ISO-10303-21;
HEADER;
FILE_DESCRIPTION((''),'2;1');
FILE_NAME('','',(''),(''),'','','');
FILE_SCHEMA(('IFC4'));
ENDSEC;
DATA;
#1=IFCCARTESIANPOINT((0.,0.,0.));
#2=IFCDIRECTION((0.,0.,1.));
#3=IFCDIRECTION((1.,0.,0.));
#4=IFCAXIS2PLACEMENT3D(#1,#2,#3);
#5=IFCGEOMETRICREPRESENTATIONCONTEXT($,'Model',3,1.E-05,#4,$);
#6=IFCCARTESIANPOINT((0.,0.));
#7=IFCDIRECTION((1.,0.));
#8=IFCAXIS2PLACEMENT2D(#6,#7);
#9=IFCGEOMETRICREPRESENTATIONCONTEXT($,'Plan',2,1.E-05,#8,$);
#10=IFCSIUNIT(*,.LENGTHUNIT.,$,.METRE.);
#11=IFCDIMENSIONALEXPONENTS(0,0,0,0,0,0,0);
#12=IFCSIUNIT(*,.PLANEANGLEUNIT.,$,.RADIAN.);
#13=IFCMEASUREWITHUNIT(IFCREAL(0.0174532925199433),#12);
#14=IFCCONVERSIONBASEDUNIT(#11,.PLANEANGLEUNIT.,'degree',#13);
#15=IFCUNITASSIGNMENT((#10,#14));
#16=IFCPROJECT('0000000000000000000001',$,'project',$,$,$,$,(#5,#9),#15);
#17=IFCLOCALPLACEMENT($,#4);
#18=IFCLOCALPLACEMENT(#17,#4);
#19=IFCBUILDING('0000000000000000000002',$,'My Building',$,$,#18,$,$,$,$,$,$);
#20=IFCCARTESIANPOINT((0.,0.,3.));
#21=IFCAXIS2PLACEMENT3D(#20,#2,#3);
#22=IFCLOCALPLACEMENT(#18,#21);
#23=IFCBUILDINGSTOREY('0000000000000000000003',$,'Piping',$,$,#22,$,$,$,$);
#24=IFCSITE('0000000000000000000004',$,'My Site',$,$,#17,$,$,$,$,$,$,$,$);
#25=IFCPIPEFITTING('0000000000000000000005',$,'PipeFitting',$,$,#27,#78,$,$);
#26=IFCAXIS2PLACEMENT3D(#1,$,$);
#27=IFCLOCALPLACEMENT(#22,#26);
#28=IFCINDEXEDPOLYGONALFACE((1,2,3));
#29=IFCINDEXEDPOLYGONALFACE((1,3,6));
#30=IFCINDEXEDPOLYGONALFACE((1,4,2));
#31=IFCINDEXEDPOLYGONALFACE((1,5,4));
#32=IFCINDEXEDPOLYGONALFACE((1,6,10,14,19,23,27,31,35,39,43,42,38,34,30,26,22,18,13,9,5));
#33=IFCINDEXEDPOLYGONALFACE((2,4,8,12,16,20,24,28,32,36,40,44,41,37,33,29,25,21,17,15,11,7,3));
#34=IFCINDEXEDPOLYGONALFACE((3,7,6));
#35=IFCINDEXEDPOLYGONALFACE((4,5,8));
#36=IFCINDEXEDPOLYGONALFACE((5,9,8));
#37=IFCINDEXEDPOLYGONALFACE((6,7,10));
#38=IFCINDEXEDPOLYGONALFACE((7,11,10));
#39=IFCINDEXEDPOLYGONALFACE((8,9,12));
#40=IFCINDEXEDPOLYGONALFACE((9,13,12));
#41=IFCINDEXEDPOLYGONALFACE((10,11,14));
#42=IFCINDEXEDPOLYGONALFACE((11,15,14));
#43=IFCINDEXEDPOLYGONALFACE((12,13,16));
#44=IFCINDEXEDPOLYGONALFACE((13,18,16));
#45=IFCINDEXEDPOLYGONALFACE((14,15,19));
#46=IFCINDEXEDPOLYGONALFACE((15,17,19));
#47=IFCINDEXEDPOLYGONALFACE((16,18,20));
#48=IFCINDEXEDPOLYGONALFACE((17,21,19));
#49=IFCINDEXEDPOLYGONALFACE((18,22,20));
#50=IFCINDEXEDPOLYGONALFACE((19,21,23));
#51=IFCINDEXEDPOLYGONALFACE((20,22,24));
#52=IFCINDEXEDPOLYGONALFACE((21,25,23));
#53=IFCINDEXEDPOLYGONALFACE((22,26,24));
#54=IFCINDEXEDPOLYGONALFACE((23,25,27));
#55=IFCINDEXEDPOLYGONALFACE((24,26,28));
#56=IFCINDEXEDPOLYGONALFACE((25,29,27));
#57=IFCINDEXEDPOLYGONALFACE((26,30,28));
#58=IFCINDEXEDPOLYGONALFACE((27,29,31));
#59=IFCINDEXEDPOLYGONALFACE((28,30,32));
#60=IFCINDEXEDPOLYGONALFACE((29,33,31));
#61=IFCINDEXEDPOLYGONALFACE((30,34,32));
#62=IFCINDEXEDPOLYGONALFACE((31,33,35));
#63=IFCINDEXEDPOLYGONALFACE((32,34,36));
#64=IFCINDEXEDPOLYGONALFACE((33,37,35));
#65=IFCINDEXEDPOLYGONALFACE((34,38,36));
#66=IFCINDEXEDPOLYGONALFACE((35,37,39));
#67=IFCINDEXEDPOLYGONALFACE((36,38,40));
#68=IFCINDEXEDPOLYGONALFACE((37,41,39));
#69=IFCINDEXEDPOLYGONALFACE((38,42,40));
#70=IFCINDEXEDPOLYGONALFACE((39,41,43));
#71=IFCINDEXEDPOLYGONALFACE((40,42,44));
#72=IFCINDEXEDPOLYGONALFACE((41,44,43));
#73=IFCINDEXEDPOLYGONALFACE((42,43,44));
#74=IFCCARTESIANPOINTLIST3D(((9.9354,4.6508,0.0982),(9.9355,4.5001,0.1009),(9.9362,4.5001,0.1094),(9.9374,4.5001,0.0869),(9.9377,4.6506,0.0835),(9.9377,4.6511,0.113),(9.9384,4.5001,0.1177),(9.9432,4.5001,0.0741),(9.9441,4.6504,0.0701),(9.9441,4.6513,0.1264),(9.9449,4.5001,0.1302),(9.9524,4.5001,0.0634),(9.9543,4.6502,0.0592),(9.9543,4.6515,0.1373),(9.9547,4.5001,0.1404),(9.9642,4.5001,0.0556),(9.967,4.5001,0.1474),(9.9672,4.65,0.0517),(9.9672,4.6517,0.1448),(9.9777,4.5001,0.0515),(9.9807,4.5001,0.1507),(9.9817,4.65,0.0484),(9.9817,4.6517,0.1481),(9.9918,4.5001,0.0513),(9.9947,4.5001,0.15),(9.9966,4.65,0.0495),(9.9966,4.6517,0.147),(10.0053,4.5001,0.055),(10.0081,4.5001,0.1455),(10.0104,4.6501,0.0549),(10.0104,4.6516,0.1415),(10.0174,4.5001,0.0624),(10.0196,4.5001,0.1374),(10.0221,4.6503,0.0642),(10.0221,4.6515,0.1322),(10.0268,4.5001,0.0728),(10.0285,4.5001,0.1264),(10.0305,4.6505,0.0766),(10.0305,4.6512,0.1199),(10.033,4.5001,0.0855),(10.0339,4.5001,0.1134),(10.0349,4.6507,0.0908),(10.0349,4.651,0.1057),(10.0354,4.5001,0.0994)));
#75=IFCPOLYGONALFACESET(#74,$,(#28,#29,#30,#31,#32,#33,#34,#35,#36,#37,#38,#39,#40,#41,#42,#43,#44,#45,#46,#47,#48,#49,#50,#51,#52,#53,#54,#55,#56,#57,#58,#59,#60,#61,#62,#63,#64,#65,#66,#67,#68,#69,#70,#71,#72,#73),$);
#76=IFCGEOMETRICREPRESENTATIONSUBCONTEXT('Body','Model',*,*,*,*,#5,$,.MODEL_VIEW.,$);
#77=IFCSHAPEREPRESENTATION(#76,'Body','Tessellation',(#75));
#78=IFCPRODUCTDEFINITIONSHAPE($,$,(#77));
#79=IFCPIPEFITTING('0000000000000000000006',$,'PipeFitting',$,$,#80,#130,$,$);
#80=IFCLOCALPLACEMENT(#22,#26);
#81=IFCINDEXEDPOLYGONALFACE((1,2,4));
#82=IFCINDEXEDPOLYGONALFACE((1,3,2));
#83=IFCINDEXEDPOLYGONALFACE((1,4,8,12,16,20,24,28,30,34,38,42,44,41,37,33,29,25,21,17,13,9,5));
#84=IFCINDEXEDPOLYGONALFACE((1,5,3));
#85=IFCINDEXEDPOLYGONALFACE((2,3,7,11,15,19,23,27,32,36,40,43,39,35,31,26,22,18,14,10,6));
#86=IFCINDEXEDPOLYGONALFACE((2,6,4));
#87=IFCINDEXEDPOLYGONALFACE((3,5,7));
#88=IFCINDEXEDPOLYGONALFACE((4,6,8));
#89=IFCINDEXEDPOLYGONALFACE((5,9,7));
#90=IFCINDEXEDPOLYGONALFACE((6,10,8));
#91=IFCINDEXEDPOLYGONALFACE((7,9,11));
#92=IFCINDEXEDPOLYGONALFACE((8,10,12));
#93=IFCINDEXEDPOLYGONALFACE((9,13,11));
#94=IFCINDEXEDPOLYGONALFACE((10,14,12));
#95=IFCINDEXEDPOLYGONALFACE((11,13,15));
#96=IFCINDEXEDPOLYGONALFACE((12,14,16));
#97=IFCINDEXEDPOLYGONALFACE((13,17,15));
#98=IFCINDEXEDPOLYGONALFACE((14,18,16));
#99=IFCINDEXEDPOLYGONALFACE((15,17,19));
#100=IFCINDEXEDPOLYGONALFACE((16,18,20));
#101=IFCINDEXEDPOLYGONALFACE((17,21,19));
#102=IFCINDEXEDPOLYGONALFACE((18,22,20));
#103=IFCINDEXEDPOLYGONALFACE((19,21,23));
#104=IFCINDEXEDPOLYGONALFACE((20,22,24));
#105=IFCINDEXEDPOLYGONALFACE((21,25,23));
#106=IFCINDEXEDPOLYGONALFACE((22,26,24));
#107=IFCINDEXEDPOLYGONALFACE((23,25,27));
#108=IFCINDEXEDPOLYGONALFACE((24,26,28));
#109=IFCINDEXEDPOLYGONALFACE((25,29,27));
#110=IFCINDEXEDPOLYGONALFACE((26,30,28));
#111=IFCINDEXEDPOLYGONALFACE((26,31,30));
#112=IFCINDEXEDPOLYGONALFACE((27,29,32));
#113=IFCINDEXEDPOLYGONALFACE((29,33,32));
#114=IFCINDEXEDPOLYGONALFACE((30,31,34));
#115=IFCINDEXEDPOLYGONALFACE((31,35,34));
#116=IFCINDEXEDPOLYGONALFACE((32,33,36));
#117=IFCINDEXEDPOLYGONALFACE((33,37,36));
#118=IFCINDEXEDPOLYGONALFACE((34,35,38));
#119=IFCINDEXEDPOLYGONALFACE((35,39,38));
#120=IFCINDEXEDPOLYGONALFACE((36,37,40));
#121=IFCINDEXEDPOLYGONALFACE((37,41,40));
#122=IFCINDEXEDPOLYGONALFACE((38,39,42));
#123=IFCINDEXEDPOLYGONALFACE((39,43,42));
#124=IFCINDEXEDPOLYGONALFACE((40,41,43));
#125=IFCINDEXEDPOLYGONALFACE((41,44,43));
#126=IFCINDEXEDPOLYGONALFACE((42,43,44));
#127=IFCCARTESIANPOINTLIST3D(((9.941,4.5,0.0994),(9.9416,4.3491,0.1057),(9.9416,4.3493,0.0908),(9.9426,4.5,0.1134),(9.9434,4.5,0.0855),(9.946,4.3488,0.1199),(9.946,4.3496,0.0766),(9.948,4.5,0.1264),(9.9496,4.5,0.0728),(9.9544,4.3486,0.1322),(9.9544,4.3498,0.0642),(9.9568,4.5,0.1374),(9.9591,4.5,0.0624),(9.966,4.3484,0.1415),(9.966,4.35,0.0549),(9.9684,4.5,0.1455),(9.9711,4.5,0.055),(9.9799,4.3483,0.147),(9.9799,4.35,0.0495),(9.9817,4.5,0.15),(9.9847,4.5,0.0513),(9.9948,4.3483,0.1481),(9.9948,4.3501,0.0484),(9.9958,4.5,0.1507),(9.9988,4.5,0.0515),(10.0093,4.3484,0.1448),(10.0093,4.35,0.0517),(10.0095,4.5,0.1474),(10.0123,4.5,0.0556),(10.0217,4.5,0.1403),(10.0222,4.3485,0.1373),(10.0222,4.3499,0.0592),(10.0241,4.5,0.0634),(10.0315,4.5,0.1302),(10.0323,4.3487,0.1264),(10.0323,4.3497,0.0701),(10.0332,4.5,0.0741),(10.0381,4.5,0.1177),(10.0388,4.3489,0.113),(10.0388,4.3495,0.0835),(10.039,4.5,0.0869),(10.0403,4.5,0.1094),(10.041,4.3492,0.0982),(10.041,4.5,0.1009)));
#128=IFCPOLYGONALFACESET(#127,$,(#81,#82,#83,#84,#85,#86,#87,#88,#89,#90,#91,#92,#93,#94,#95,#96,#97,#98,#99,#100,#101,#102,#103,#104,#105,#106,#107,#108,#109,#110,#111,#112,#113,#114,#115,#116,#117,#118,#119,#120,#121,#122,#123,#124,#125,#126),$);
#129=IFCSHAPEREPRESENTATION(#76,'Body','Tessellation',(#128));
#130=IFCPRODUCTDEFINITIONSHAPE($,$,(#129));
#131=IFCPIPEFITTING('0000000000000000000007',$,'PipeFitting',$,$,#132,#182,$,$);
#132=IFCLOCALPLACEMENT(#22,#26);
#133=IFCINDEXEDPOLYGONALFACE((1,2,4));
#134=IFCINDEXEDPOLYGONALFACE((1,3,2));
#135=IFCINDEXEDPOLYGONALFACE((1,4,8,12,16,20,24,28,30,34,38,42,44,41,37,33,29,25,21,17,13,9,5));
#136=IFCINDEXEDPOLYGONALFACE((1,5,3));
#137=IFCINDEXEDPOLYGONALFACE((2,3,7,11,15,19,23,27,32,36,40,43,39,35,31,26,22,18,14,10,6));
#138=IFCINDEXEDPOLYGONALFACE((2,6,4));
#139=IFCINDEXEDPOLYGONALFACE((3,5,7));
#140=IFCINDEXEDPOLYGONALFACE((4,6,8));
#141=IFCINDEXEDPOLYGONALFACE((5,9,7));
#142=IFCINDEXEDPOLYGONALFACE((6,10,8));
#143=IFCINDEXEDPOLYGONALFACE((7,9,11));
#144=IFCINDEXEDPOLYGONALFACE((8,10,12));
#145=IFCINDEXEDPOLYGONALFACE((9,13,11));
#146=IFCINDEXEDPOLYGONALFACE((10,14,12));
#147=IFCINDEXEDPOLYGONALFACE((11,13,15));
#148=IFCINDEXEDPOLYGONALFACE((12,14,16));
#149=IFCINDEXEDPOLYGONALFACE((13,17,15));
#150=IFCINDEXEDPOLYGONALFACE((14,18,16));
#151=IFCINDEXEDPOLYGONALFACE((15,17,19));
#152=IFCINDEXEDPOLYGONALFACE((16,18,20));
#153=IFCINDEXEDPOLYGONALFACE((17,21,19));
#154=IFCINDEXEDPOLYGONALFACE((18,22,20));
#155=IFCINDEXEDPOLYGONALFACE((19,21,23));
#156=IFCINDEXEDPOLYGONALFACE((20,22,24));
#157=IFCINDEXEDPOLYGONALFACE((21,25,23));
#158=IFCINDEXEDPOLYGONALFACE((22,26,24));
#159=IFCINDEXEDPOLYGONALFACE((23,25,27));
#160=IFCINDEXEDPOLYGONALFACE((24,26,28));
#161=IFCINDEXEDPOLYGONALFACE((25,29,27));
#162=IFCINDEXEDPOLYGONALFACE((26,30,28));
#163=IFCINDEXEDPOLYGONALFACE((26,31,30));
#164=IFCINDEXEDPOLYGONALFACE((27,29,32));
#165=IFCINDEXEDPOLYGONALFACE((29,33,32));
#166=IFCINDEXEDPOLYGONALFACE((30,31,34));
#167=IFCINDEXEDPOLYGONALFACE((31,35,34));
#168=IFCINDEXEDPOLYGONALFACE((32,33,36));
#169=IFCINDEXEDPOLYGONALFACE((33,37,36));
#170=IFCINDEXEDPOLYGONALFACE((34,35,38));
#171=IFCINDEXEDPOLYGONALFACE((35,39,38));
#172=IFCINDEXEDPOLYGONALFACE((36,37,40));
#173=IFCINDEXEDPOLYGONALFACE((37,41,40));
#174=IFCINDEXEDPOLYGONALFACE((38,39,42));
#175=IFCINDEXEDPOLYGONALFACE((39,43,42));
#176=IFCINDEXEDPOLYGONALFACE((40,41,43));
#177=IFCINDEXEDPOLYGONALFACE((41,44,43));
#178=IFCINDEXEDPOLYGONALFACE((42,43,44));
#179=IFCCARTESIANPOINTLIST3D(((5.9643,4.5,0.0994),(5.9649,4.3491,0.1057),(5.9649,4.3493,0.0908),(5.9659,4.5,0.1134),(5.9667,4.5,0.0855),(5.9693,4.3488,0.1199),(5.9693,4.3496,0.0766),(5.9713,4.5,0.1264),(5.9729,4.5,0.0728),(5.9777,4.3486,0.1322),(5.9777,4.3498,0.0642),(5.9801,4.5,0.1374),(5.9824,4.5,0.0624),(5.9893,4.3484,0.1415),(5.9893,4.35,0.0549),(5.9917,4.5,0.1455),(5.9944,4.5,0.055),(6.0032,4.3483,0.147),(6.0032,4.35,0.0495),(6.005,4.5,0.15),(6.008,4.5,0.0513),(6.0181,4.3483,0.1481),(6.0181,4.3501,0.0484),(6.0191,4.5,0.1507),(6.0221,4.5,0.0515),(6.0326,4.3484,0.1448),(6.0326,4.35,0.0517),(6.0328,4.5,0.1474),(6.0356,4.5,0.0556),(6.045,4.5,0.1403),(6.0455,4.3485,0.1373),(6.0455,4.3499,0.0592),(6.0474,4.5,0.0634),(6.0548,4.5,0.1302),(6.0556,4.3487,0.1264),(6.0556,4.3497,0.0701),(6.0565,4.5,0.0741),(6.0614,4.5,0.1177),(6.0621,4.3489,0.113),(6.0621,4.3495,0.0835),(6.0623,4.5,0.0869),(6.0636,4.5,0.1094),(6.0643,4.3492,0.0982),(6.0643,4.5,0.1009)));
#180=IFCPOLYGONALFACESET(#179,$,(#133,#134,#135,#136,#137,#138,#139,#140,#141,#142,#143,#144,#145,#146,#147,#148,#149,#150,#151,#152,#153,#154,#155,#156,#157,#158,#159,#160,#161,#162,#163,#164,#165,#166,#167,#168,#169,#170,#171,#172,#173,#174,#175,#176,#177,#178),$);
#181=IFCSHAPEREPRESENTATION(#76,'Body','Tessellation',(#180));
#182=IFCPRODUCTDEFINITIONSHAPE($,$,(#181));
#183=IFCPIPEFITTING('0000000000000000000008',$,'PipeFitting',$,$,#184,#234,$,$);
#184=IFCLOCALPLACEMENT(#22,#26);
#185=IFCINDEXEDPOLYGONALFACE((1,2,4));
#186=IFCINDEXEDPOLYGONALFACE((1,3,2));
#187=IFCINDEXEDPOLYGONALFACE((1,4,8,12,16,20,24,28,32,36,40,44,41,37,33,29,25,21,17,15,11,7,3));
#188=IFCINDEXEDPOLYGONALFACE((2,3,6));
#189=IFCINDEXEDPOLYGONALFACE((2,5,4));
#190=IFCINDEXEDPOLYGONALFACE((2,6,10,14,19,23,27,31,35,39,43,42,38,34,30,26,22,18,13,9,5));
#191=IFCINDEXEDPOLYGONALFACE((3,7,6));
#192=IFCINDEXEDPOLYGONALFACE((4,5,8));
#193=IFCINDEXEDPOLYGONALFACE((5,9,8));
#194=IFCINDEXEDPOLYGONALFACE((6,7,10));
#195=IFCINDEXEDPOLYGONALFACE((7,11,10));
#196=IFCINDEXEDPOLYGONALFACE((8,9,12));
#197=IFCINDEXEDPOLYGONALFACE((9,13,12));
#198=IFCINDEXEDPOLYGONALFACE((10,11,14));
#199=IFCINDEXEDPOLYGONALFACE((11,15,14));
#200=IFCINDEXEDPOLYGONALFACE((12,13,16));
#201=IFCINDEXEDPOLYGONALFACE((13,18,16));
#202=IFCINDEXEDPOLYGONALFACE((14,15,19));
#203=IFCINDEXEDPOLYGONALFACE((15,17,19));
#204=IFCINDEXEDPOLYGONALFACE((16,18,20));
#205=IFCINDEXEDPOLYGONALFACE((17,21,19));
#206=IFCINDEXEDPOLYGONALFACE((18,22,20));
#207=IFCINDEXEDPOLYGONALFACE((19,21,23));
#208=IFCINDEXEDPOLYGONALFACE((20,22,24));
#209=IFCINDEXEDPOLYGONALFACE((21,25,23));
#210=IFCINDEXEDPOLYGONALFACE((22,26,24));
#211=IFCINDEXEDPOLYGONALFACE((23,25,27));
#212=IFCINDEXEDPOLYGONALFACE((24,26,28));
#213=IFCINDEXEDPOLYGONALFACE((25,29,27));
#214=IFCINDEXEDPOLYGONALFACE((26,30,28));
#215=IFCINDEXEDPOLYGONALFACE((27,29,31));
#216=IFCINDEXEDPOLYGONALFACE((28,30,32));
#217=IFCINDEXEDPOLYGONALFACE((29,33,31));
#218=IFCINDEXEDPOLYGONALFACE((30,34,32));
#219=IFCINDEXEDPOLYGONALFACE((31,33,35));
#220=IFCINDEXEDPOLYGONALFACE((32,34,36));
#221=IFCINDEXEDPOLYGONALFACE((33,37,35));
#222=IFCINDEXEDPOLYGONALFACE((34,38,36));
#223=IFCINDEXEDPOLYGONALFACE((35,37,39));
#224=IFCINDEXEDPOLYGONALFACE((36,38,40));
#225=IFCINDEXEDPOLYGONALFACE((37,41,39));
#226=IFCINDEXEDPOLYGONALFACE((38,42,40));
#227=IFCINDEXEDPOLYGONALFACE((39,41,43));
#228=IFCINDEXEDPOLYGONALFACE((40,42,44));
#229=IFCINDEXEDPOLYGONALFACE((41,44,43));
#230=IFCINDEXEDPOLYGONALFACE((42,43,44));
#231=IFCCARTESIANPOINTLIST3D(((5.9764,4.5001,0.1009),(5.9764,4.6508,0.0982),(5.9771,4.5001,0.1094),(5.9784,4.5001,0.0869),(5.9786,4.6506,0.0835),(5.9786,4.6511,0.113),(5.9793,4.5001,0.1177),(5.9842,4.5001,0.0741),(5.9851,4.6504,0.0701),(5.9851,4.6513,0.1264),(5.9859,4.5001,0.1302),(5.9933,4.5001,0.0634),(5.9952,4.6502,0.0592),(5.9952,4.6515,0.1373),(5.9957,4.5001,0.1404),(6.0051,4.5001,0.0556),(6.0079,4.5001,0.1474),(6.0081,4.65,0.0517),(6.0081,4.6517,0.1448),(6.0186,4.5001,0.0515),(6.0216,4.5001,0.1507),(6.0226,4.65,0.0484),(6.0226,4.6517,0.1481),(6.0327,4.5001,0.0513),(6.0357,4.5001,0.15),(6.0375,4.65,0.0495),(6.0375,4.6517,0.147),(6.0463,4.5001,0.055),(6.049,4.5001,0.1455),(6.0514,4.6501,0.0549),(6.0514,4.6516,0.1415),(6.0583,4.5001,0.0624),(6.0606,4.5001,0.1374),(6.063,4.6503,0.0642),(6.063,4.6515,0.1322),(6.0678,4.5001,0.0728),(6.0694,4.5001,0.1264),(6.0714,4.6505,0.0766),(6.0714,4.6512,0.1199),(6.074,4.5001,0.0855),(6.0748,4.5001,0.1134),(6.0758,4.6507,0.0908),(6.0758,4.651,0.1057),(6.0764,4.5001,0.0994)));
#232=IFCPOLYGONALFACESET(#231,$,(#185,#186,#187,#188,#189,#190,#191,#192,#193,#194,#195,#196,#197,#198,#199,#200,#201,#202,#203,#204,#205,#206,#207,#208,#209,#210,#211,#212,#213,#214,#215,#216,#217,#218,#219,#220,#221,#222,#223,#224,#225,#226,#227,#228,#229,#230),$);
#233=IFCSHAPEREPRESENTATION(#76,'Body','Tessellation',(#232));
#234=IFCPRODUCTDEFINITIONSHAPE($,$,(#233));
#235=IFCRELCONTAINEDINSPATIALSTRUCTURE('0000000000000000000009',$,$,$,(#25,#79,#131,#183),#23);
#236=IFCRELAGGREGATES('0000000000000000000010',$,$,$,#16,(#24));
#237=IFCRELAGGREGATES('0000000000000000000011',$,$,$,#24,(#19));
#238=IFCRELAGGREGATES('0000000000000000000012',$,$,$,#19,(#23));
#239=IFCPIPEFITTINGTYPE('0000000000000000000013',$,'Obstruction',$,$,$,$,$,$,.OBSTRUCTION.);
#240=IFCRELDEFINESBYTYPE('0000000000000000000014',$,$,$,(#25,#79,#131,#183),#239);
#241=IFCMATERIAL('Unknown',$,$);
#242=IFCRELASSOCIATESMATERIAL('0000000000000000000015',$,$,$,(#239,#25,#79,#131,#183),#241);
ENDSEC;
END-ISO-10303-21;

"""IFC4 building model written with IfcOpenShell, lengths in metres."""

from ifc_helpers import new_model, entity, si_unit, converted_unit, frame, origin_with_axes, origin_2d_with_axis, place, context, subcontext, project, spatial, circle, extrude, clip, halfspace, material, material_profile, profile_set, profile_usage, type_object, element, save


model = new_model("IFC4")

# Units and contexts
model_context = context("Model", 3, precision=1e-05, world=origin_with_axes())
plan_context = context("Plan", 2, precision=1e-05, world=origin_2d_with_axis())
body_context = subcontext(model_context, "Body", "Model", "MODEL_VIEW")
ifc_project = project(units=[si_unit("LENGTHUNIT", "METRE"), converted_unit("PLANEANGLEUNIT", "degree", entity("IfcReal", 0.0174532925199433), si_unit("PLANEANGLEUNIT", "RADIAN"), dimensions=[0, 0, 0, 0, 0, 0, 0])], contexts=[model_context, plan_context])

# Site, building, storey
site_placement = place(None, origin_with_axes())
site = spatial("IfcSite", under=ifc_project, at=site_placement, Name="My Site")
building_placement = place(site_placement, origin_with_axes())
building = spatial("IfcBuilding", under=site, at=building_placement, Name="My Building")
storey_placement = place(building_placement, frame((0.0, 0.0, 3.0), z_axis=(0.0, 0.0, 1.0), x_axis=(1.0, 0.0, 0.0)))
storey = spatial("IfcBuildingStorey", under=building, at=storey_placement, Name="Piping")

# Shared definitions
ifc_material = material(Name="Unknown")

# Pipe fittings
ifc_material_profile_1 = material_profile(ifc_material, circle(Radius=0.05))
ifc_profile_set_1 = profile_set([ifc_material_profile_1])
ifc_profile_usage_1 = profile_usage(ifc_profile_set_1, cardinal=5)
pipe_fitting_type_1 = type_object("IfcPipeFittingType", Name="Obstruction", PredefinedType="OBSTRUCTION", material=ifc_profile_set_1)
pipe_fitting_1_placement = place(storey_placement, frame((9.9856, 2.988, 0.1275), z_axis=(-0.000099, 0.999846, -0.017575), x_axis=(-1.0, -0.000099, 0.0)))
element("IfcPipeFitting", 1, at=pipe_fitting_1_placement, inside=storey, type_object=pipe_fitting_type_1, material=ifc_profile_usage_1, Name="PipeFitting", context=body_context, shape_type="Clipping", body=[
    clip(extrude(circle(Radius=0.05), origin_with_axes(), (0.0, 0.0, 1.0), 1.6631), halfspace(frame((9.986, 0.0496, 1.5112), z_axis=(-0.000023, -0.017575, -0.999846), x_axis=(-0.999999, 0.001299, 0.0)), False)),
])
ifc_profile_usage_2 = profile_usage(ifc_profile_set_1, cardinal=5)
pipe_fitting_2_placement = place(storey_placement, frame((9.9909, 6.0122, 0.1275), z_axis=(0.000099, -0.999846, -0.017575), x_axis=(1.0, 0.000099, -0.000001)))
element("IfcPipeFitting", 2, at=pipe_fitting_2_placement, inside=storey, type_object=pipe_fitting_type_1, material=ifc_profile_usage_2, Name="PipeFitting", context=body_context, shape_type="Clipping", body=[
    clip(extrude(circle(Radius=0.05), origin_with_axes(), (0.0, 0.0, 1.0), 1.6632), halfspace(frame((-9.9916, 0.0496, 1.5117), z_axis=(-0.000023, -0.017575, -0.999846), x_axis=(-0.999999, 0.001299, 0.0)), False)),
])
ifc_profile_usage_3 = profile_usage(ifc_profile_set_1, cardinal=5)
pipe_fitting_3_placement = place(storey_placement, frame((6.0142, 6.0122, 0.1275), z_axis=(0.000099, -0.999846, -0.017575), x_axis=(1.0, 0.000099, -0.000001)))
element("IfcPipeFitting", 3, at=pipe_fitting_3_placement, inside=storey, type_object=pipe_fitting_type_1, material=ifc_profile_usage_3, Name="PipeFitting", context=body_context, shape_type="Clipping", body=[
    clip(extrude(circle(Radius=0.05), origin_with_axes(), (0.0, 0.0, 1.0), 1.6632), halfspace(frame((-6.0149, 0.0496, 1.5116), z_axis=(-0.000023, -0.01745, -0.999848), x_axis=(-0.999999, 0.001308, 0.0)), False)),
])
ifc_profile_usage_4 = profile_usage(ifc_profile_set_1, cardinal=5)
pipe_fitting_4_placement = place(storey_placement, frame((6.0265, 2.988, 0.1275), z_axis=(-0.000099, 0.999846, -0.017575), x_axis=(-1.0, -0.000099, 0.0)))
element("IfcPipeFitting", 4, at=pipe_fitting_4_placement, inside=storey, type_object=pipe_fitting_type_1, material=ifc_profile_usage_4, Name="PipeFitting", context=body_context, shape_type="Clipping", body=[
    clip(extrude(circle(Radius=0.05), origin_with_axes(), (0.0, 0.0, 1.0), 1.6631), halfspace(frame((6.0269, 0.0496, 1.5113), z_axis=(-0.000023, -0.017633, -0.999845), x_axis=(-0.999999, 0.001295, 0.0)), False)),
])

save(model, "model.ifc")
